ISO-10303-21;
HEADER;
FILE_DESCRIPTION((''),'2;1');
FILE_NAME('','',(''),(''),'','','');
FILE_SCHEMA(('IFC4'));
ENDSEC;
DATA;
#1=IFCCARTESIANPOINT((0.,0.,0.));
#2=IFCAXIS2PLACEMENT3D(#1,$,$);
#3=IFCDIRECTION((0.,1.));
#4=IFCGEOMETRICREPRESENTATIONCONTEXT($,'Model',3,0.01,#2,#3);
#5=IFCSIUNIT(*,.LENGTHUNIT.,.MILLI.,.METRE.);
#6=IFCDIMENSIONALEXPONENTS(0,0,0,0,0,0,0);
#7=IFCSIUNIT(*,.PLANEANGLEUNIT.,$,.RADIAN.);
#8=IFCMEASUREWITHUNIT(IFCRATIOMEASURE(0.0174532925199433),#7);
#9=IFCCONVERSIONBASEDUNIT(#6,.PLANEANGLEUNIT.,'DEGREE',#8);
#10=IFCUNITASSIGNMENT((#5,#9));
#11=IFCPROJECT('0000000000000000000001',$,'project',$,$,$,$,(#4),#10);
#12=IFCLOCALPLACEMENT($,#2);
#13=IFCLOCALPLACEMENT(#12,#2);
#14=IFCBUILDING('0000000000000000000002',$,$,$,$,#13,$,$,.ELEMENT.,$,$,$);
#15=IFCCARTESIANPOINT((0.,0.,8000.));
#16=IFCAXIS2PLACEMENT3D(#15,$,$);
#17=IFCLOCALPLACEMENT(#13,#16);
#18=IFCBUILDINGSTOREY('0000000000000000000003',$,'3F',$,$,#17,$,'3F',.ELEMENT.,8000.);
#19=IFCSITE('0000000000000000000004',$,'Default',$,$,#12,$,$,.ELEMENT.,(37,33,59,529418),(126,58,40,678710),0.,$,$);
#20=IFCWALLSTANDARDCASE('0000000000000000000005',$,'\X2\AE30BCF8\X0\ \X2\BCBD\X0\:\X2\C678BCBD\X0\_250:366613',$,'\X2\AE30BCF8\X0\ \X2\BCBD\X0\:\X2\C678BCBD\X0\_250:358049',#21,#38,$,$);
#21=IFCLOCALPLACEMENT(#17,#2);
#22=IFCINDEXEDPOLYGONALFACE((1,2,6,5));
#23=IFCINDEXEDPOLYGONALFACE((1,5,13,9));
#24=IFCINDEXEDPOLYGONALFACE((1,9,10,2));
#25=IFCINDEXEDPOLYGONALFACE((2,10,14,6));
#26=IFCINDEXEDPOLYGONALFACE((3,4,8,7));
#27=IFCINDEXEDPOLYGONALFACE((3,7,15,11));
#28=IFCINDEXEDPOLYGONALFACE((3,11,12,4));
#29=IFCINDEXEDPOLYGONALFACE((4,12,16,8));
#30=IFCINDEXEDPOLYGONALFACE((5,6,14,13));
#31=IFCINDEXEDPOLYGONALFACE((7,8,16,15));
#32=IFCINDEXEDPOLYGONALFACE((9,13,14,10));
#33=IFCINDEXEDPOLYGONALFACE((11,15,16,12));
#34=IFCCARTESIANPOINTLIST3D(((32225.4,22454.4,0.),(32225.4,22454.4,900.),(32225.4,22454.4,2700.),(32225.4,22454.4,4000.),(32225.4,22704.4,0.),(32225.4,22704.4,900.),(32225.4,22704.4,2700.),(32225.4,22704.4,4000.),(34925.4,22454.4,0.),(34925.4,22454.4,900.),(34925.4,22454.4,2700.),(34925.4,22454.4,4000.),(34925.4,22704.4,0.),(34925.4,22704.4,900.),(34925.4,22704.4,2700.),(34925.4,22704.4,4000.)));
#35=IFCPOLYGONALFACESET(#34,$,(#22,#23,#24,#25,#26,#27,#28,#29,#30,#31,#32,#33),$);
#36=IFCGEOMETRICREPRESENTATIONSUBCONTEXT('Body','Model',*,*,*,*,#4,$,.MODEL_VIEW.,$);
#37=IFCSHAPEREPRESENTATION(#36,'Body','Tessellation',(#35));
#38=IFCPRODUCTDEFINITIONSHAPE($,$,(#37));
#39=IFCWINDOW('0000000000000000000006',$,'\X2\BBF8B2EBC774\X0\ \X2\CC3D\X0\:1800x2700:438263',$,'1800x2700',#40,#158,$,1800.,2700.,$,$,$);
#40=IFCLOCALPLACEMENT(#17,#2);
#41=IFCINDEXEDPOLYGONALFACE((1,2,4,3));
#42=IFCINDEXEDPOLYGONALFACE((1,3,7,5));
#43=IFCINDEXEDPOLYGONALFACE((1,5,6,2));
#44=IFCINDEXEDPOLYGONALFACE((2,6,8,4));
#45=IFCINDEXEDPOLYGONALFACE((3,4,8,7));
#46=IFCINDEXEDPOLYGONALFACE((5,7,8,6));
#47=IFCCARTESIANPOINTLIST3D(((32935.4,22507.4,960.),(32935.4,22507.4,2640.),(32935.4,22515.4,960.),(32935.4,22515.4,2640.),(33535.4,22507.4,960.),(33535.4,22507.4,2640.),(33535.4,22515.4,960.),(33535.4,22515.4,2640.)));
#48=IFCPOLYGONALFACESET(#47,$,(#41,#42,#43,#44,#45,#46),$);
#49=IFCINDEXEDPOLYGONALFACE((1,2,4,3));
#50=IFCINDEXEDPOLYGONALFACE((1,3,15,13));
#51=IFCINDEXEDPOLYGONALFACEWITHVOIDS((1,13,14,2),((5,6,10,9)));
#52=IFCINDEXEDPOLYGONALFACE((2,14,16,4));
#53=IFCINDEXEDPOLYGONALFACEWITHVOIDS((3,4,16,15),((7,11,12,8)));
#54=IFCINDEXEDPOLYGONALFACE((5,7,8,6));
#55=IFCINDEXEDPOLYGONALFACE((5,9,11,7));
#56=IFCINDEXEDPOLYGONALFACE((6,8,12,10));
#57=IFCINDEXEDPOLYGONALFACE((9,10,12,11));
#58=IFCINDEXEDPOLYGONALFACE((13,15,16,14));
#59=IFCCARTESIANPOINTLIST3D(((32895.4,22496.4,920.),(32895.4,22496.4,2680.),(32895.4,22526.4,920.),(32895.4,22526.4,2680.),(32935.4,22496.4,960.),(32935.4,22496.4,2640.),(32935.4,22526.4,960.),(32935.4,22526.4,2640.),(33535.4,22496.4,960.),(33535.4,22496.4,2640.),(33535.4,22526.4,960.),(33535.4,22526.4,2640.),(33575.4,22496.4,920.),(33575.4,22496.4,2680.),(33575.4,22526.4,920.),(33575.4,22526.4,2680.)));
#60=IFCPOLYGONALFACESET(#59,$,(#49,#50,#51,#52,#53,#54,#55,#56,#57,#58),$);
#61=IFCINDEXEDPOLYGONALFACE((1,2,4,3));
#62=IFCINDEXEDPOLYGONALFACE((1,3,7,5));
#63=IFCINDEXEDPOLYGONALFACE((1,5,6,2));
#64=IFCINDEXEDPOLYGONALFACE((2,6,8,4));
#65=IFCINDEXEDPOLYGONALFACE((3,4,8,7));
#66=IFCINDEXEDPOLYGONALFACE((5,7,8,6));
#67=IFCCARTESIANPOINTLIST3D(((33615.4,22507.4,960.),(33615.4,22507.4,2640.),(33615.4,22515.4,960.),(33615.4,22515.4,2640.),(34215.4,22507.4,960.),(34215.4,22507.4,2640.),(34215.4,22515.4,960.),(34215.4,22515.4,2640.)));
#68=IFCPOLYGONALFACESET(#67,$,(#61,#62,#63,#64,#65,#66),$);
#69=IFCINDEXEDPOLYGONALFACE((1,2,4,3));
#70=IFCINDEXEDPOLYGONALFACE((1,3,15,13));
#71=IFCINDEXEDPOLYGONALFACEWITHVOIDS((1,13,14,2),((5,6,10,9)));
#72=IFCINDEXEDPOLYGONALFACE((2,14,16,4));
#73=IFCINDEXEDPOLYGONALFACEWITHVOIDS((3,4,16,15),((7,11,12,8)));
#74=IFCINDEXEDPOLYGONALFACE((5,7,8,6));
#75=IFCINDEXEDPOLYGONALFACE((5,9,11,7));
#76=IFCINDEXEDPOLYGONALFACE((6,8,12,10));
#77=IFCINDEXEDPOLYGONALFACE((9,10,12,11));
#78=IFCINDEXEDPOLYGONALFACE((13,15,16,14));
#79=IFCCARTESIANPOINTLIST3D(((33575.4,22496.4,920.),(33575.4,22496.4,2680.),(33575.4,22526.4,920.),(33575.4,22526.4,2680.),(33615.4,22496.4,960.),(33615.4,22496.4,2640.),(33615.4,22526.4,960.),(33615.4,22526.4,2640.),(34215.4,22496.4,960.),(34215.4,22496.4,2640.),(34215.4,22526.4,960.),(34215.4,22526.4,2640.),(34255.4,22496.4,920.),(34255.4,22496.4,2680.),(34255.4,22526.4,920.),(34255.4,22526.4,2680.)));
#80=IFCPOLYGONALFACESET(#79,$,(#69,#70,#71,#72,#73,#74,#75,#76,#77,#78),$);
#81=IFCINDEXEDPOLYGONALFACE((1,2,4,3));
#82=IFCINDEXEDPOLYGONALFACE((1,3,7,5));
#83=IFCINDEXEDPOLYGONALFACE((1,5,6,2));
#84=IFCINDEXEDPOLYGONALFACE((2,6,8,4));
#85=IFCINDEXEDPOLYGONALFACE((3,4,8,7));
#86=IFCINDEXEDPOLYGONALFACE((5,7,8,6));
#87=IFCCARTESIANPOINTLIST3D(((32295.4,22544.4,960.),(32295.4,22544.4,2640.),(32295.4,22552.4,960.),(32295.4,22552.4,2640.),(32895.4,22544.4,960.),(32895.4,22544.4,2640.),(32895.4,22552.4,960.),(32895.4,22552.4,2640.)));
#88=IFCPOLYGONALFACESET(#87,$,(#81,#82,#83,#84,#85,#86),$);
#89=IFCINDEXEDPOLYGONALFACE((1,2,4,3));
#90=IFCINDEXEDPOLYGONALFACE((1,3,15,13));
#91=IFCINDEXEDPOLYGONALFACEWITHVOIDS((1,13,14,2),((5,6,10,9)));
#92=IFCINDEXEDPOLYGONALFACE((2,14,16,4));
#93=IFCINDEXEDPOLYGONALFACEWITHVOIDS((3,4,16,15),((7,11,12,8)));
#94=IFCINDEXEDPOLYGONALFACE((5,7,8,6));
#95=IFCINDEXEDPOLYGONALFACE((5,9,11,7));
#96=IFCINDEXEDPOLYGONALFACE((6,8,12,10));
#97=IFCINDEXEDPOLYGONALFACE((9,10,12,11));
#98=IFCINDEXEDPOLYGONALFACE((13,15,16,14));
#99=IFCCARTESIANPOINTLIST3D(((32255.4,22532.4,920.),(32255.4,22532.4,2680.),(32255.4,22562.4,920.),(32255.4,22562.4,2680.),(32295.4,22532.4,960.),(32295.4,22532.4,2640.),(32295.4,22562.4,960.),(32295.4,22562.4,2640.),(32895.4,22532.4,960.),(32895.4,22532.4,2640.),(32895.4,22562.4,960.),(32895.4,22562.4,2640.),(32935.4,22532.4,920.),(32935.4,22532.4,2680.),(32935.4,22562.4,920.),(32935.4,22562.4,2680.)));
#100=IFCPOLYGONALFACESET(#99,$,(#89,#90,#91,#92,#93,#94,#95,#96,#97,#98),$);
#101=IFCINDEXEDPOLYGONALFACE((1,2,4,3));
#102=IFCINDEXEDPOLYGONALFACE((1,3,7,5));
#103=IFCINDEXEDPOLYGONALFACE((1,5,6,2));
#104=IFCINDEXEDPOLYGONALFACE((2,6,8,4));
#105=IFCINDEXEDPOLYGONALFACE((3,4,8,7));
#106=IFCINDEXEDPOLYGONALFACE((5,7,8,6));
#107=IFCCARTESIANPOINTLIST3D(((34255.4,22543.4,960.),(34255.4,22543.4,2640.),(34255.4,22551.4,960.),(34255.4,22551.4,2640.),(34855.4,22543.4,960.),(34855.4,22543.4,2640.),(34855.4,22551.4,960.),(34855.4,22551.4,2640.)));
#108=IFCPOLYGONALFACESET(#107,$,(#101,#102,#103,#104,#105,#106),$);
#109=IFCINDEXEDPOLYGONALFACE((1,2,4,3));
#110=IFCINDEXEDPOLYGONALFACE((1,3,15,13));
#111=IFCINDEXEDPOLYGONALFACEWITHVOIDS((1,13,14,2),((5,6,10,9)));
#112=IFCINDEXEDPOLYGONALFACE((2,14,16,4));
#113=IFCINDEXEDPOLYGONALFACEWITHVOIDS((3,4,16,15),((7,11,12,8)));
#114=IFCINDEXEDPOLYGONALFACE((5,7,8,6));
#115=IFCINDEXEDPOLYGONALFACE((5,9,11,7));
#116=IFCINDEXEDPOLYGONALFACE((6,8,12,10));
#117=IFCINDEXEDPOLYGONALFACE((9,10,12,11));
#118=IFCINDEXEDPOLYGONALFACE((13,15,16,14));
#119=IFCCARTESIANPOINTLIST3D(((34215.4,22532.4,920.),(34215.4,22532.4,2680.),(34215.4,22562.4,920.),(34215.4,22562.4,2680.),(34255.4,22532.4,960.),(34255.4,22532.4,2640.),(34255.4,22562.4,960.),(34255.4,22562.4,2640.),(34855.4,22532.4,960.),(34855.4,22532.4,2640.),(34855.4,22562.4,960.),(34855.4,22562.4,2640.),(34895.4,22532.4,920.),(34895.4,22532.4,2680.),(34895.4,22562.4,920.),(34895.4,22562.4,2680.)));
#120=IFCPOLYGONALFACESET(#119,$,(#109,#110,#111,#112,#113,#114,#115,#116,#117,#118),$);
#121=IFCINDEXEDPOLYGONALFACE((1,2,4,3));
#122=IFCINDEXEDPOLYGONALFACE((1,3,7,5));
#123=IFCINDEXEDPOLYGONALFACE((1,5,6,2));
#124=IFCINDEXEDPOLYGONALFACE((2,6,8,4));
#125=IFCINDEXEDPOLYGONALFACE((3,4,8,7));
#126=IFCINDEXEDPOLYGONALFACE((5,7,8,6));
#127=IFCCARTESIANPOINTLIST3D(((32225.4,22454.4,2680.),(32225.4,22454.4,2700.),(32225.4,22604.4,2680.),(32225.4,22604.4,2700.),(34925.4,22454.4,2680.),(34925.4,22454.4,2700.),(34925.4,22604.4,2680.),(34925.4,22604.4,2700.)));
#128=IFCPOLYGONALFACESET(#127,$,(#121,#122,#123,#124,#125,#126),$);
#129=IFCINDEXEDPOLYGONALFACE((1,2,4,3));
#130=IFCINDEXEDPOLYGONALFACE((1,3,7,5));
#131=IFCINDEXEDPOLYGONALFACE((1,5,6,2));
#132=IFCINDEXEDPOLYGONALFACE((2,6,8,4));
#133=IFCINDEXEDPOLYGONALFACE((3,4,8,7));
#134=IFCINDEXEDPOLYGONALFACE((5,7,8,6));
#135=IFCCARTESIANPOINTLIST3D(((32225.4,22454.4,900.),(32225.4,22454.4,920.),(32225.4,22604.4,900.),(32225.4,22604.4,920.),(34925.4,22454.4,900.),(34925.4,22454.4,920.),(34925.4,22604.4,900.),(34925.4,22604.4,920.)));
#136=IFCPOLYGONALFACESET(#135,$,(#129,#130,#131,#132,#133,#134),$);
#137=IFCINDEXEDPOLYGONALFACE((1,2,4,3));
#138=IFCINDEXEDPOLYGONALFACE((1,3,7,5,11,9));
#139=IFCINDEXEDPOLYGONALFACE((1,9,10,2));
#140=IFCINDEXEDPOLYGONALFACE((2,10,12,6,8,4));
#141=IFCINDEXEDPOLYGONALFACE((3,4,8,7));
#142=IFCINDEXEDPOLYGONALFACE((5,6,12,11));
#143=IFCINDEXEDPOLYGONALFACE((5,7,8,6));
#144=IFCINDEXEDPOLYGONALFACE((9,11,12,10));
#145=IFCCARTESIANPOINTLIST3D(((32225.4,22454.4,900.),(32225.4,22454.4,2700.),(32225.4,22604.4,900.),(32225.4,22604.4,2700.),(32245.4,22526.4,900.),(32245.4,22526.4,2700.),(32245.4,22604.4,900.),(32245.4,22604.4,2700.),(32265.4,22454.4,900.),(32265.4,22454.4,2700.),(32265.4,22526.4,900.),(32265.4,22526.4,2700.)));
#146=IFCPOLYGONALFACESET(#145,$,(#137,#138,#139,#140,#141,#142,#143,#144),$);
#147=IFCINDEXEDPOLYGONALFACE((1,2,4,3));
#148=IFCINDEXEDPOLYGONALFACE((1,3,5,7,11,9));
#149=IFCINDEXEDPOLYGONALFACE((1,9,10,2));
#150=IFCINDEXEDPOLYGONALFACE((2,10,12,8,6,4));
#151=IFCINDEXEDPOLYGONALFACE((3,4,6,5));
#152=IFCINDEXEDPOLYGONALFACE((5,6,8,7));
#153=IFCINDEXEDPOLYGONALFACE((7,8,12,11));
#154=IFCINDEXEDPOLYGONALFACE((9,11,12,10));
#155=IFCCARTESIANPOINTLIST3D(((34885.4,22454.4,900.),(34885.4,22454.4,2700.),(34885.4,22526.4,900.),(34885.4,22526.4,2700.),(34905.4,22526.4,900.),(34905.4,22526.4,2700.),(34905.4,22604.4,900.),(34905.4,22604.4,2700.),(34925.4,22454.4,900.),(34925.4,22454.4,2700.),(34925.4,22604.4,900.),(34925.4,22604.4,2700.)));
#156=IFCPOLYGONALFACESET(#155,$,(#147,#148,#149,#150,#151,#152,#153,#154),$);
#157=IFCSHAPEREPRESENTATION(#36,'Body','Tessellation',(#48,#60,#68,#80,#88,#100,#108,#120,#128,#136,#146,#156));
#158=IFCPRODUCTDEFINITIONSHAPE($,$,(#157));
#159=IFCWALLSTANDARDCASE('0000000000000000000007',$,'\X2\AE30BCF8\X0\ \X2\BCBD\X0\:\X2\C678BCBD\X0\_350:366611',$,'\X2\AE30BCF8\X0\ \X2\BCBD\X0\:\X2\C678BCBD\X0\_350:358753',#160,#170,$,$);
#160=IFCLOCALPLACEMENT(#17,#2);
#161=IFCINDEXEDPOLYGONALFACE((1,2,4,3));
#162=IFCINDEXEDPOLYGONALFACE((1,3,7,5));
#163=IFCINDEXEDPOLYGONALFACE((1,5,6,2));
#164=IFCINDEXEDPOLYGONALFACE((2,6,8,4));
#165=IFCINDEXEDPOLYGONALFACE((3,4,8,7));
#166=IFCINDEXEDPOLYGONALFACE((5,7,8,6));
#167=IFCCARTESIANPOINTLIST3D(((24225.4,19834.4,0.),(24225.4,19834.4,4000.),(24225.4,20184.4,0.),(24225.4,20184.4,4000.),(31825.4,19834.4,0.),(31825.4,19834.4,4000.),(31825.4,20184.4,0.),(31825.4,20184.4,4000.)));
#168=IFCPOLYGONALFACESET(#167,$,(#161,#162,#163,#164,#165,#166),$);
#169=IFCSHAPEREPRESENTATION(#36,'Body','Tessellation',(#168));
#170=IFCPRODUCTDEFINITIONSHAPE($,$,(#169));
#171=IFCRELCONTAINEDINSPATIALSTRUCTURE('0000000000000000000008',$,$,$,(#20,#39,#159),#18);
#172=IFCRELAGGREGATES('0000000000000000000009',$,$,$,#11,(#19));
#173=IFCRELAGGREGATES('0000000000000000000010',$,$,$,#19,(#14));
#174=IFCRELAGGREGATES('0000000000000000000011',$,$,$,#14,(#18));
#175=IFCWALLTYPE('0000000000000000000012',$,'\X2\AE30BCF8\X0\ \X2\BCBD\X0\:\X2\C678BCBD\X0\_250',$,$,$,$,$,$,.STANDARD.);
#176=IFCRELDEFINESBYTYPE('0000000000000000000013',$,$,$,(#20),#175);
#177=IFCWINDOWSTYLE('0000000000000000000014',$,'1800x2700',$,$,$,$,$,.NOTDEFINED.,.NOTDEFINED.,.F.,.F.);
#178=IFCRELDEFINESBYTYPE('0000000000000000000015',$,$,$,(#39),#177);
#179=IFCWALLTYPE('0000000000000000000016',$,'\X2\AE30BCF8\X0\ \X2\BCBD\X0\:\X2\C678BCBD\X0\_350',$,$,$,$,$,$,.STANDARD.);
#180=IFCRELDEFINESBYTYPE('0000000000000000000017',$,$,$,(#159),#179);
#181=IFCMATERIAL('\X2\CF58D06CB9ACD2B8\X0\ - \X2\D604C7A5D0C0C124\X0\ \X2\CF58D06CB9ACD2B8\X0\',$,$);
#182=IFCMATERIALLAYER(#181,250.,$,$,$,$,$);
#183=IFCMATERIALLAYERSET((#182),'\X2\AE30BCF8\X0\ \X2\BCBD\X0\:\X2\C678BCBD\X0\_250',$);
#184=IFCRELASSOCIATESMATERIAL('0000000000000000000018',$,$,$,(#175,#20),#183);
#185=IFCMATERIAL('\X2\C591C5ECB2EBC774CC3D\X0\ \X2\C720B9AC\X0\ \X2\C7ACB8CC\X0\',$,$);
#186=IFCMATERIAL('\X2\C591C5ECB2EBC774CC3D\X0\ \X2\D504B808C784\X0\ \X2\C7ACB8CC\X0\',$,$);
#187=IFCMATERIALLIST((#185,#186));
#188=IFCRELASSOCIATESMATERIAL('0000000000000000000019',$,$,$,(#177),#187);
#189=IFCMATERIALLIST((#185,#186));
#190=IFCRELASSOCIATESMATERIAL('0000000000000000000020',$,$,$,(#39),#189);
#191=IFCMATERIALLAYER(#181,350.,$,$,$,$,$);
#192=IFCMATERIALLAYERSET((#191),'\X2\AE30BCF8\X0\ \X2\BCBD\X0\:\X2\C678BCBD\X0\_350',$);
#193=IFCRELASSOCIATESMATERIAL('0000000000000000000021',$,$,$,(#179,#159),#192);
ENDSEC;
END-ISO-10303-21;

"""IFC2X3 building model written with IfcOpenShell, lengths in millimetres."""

from ifc_helpers import new_model, entity, si_unit, converted_unit, direction, frame, frame_2d, origin, origin_2d_with_axis, place, context, subcontext, project, spatial, polyline, rectangle, outline, extrude, source, transform, mapped, material, material_list, layer, layer_set, layer_usage, type_object, type_shapes, element, fill, save


model = new_model("IFC2X3")

# Units and contexts
model_context = context("Model", 3, precision=0.01, world=origin(), true_north=direction((0.0, 1.0)))
body_context = subcontext(model_context, "Body", "Model", "MODEL_VIEW")
ifc_project = project(units=[si_unit("LENGTHUNIT", "METRE", prefix="MILLI"), converted_unit("PLANEANGLEUNIT", "DEGREE", entity("IfcRatioMeasure", 0.0174532925199433), si_unit("PLANEANGLEUNIT", "RADIAN"), dimensions=[0, 0, 0, 0, 0, 0, 0])], contexts=[model_context])

# Site, building, storey
site_placement = place(None, origin())
site = spatial("IfcSite", under=ifc_project, at=site_placement, Name="Default", CompositionType="ELEMENT", RefLatitude=(37, 33, 59, 529418), RefLongitude=(126, 58, 40, 678710), RefElevation=0.0)
building_placement = place(site_placement, origin())
building = spatial("IfcBuilding", under=site, at=building_placement, CompositionType="ELEMENT")
storey_placement = place(building_placement, frame((0.0, 0.0, 8000.0)))
storey = spatial("IfcBuildingStorey", under=building, at=storey_placement, Name="3F", LongName="3F", CompositionType="ELEMENT", Elevation=8000.0)

# Shared definitions
ifc_material_1 = material(Name="콘크리트 - 현장타설 콘크리트")

# Wall, opening, window
ifc_material_2 = material(Name="양여닫이창 유리 재료")
ifc_material_3 = material(Name="양여닫이창 프레임 재료")
ifc_layer_1 = layer(ifc_material_1, 250.0)
ifc_layer_set_1 = layer_set([ifc_layer_1], Name="기본 벽:외벽_250")
ifc_layer_usage_1 = layer_usage(ifc_layer_set_1, "AXIS2", "NEGATIVE", 125.0)
wall_type_1 = type_object("IfcWallType", Name="기본 벽:외벽_250", PredefinedType="STANDARD", material=ifc_layer_set_1)
wall_1_placement = place(storey_placement, frame((34925.4, 22579.4, 0.0), z_axis=(0.0, 0.0, 1.0), x_axis=(-1.0, 0.0, 0.0)))
wall_1 = element("IfcWallStandardCase", 1, at=wall_1_placement, inside=storey, type_object=wall_type_1, material=ifc_layer_usage_1, Name="기본 벽:외벽_250:366613", ObjectType="기본 벽:외벽_250:358049", context=body_context, shape_type="SweptSolid", body=[
    extrude(rectangle(XDim=2700.0, YDim=250.0, at=frame_2d((1350.0, 0.0), x_axis=(-1.0, 0.0))), origin(), (0.0, 0.0, 1.0), 4000.0),
])
opening_1_placement = place(wall_1_placement, frame((0.0, -125.0, 900.0)))
opening_1 = element("IfcOpeningElement", 2, at=opening_1_placement, cuts=wall_1, ObjectType="Opening", context=body_context, shape_type="SweptSolid", body=[
    extrude(rectangle(XDim=1800.0, YDim=2700.0, at=frame_2d((900.0, 1350.0), x_axis=(1.0, 0.0))), frame((0.0, 0.0, 0.0), z_axis=(0.0, 1.0, 0.0), x_axis=(0.0, 0.0, 1.0)), (0.0, 0.0, 1.0), 250.0),
])
ifc_material_list_1 = material_list([ifc_material_2, ifc_material_3])
ifc_material_list_2 = material_list([ifc_material_2, ifc_material_3])
window_style_1 = type_object("IfcWindowStyle", Name="1800x2700", ConstructionType="NOTDEFINED", OperationType="NOTDEFINED", ParameterTakesPrecedence=False, Sizeable=False, material=ifc_material_list_2)
shared_shape_1 = source(origin(), body_context, "Body", "SweptSolid", [
    extrude(rectangle(XDim=8.0, YDim=600.0, at=frame_2d((0.0, 0.0), x_axis=(1.0, 0.0))), frame((1690.0, 193.0, 60.0), z_axis=(0.0, 0.0, 1.0), x_axis=(0.0, 1.0, 0.0)), (0.0, 0.0, 1.0), 1680.0),
    extrude(outline(polyline([(-880.0, -340.0), (880.0, -340.0), (880.0, 340.0), (-880.0, 340.0), (-880.0, -340.0)]), holes=[polyline([(840.0, -300.0), (-840.0, -300.0), (-840.0, 300.0), (840.0, 300.0), (840.0, -300.0)])]), frame((1690.0, 178.0, 900.0), z_axis=(0.0, 1.0, 0.0), x_axis=(0.0, 0.0, -1.0)), (0.0, 0.0, 1.0), 30.0),
    extrude(rectangle(XDim=8.0, YDim=600.0, at=origin_2d_with_axis()), frame((1010.0, 193.0, 60.0), z_axis=(0.0, 0.0, 1.0), x_axis=(0.0, 1.0, 0.0)), (0.0, 0.0, 1.0), 1680.0),
    extrude(outline(polyline([(-880.0, -340.0), (880.0, -340.0), (880.0, 340.0), (-880.0, 340.0), (-880.0, -340.0)]), holes=[polyline([(840.0, -300.0), (-840.0, -300.0), (-840.0, 300.0), (840.0, 300.0), (840.0, -300.0)])]), frame((1010.0, 178.0, 900.0), z_axis=(0.0, 1.0, 0.0), x_axis=(0.0, 0.0, -1.0)), (0.0, 0.0, 1.0), 30.0),
    extrude(rectangle(XDim=8.0, YDim=600.0, at=frame_2d((0.0, 0.0), x_axis=(1.0, 0.0))), frame((2330.0, 156.0, 60.0), z_axis=(0.0, 0.0, 1.0), x_axis=(0.0, 1.0, 0.0)), (0.0, 0.0, 1.0), 1680.0),
    extrude(outline(polyline([(-880.0, -340.0), (880.0, -340.0), (880.0, 340.0), (-880.0, 340.0), (-880.0, -340.0)]), holes=[polyline([(840.0, -300.0), (-840.0, -300.0), (-840.0, 300.0), (840.0, 300.0), (840.0, -300.0)])]), frame((2330.0, 142.0, 900.0), z_axis=(0.0, 1.0, 0.0), x_axis=(0.0, 0.0, -1.0)), (0.0, 0.0, 1.0), 30.0),
    extrude(rectangle(XDim=8.0, YDim=600.0, at=frame_2d((0.0, 0.0), x_axis=(1.0, 0.0))), frame((370.0, 157.0, 60.0), z_axis=(0.0, 0.0, 1.0), x_axis=(0.0, 1.0, 0.0)), (0.0, 0.0, 1.0), 1680.0),
    extrude(outline(polyline([(-880.0, -340.0), (880.0, -340.0), (880.0, 340.0), (-880.0, 340.0), (-880.0, -340.0)]), holes=[polyline([(840.0, -300.0), (-840.0, -300.0), (-840.0, 300.0), (840.0, 300.0), (840.0, -300.0)])]), frame((370.0, 142.0, 900.0), z_axis=(0.0, 1.0, 0.0), x_axis=(0.0, 0.0, -1.0)), (0.0, 0.0, 1.0), 30.0),
    extrude(rectangle(XDim=2700.0, YDim=150.0, at=origin_2d_with_axis()), frame((1350.0, 175.0, 1780.0), z_axis=(0.0, 0.0, 1.0), x_axis=(-1.0, 0.0, 0.0)), (0.0, 0.0, 1.0), 20.0),
    extrude(rectangle(XDim=2700.0, YDim=150.0, at=origin_2d_with_axis()), frame((1350.0, 175.0, 0.0), z_axis=(0.0, 0.0, 1.0), x_axis=(-1.0, 0.0, 0.0)), (0.0, 0.0, 1.0), 20.0),
    extrude(outline(polyline([(-74.0, -20.0), (-2.0, -20.0), (-2.0, 0.0), (76.0, 0.0), (76.0, 20.0), (-74.0, 20.0), (-74.0, -20.0)])), frame((2680.0, 176.0, 0.0), z_axis=(0.0, 0.0, 1.0), x_axis=(0.0, -1.0, 0.0)), (0.0, 0.0, 1.0), 1800.0),
    extrude(outline(polyline([(-20.0, -74.0), (20.0, -74.0), (20.0, 76.0), (0.0, 76.0), (0.0, -2.0), (-20.0, -2.0), (-20.0, -74.0)])), frame((20.0, 176.0, 0.0), z_axis=(0.0, 0.0, 1.0), x_axis=(-1.0, 0.0, 0.0)), (0.0, 0.0, 1.0), 1800.0),
])
type_shapes(window_style_1, [shared_shape_1])
window_1_placement = place(opening_1_placement, origin())
window_1 = element("IfcWindow", 3, at=window_1_placement, inside=storey, type_object=window_style_1, material=ifc_material_list_1, Name="미닫이 창:1800x2700:438263", ObjectType="1800x2700", OverallHeight=1800.0, OverallWidth=2700.0, context=body_context, shape_type="MappedRepresentation", body=[
    mapped(shared_shape_1, transform((0.0, 0.0, 0.0), scale=1.0)),
])
fill(opening_1, window_1)

# Wall
ifc_layer_2 = layer(ifc_material_1, 350.0)
ifc_layer_set_2 = layer_set([ifc_layer_2], Name="기본 벽:외벽_350")
ifc_layer_usage_2 = layer_usage(ifc_layer_set_2, "AXIS2", "NEGATIVE", 175.0)
wall_type_2 = type_object("IfcWallType", Name="기본 벽:외벽_350", PredefinedType="STANDARD", material=ifc_layer_set_2)
wall_2_placement = place(storey_placement, frame((31825.4, 20009.4, 0.0), z_axis=(0.0, 0.0, 1.0), x_axis=(-1.0, 0.0, 0.0)))
element("IfcWallStandardCase", 4, at=wall_2_placement, inside=storey, type_object=wall_type_2, material=ifc_layer_usage_2, Name="기본 벽:외벽_350:366611", ObjectType="기본 벽:외벽_350:358753", context=body_context, shape_type="SweptSolid", body=[
    extrude(rectangle(XDim=7600.0, YDim=350.0, at=frame_2d((3800.0, 0.0), x_axis=(-1.0, 0.0))), origin(), (0.0, 0.0, 1.0), 4000.0),
])

save(model, "model.ifc")
